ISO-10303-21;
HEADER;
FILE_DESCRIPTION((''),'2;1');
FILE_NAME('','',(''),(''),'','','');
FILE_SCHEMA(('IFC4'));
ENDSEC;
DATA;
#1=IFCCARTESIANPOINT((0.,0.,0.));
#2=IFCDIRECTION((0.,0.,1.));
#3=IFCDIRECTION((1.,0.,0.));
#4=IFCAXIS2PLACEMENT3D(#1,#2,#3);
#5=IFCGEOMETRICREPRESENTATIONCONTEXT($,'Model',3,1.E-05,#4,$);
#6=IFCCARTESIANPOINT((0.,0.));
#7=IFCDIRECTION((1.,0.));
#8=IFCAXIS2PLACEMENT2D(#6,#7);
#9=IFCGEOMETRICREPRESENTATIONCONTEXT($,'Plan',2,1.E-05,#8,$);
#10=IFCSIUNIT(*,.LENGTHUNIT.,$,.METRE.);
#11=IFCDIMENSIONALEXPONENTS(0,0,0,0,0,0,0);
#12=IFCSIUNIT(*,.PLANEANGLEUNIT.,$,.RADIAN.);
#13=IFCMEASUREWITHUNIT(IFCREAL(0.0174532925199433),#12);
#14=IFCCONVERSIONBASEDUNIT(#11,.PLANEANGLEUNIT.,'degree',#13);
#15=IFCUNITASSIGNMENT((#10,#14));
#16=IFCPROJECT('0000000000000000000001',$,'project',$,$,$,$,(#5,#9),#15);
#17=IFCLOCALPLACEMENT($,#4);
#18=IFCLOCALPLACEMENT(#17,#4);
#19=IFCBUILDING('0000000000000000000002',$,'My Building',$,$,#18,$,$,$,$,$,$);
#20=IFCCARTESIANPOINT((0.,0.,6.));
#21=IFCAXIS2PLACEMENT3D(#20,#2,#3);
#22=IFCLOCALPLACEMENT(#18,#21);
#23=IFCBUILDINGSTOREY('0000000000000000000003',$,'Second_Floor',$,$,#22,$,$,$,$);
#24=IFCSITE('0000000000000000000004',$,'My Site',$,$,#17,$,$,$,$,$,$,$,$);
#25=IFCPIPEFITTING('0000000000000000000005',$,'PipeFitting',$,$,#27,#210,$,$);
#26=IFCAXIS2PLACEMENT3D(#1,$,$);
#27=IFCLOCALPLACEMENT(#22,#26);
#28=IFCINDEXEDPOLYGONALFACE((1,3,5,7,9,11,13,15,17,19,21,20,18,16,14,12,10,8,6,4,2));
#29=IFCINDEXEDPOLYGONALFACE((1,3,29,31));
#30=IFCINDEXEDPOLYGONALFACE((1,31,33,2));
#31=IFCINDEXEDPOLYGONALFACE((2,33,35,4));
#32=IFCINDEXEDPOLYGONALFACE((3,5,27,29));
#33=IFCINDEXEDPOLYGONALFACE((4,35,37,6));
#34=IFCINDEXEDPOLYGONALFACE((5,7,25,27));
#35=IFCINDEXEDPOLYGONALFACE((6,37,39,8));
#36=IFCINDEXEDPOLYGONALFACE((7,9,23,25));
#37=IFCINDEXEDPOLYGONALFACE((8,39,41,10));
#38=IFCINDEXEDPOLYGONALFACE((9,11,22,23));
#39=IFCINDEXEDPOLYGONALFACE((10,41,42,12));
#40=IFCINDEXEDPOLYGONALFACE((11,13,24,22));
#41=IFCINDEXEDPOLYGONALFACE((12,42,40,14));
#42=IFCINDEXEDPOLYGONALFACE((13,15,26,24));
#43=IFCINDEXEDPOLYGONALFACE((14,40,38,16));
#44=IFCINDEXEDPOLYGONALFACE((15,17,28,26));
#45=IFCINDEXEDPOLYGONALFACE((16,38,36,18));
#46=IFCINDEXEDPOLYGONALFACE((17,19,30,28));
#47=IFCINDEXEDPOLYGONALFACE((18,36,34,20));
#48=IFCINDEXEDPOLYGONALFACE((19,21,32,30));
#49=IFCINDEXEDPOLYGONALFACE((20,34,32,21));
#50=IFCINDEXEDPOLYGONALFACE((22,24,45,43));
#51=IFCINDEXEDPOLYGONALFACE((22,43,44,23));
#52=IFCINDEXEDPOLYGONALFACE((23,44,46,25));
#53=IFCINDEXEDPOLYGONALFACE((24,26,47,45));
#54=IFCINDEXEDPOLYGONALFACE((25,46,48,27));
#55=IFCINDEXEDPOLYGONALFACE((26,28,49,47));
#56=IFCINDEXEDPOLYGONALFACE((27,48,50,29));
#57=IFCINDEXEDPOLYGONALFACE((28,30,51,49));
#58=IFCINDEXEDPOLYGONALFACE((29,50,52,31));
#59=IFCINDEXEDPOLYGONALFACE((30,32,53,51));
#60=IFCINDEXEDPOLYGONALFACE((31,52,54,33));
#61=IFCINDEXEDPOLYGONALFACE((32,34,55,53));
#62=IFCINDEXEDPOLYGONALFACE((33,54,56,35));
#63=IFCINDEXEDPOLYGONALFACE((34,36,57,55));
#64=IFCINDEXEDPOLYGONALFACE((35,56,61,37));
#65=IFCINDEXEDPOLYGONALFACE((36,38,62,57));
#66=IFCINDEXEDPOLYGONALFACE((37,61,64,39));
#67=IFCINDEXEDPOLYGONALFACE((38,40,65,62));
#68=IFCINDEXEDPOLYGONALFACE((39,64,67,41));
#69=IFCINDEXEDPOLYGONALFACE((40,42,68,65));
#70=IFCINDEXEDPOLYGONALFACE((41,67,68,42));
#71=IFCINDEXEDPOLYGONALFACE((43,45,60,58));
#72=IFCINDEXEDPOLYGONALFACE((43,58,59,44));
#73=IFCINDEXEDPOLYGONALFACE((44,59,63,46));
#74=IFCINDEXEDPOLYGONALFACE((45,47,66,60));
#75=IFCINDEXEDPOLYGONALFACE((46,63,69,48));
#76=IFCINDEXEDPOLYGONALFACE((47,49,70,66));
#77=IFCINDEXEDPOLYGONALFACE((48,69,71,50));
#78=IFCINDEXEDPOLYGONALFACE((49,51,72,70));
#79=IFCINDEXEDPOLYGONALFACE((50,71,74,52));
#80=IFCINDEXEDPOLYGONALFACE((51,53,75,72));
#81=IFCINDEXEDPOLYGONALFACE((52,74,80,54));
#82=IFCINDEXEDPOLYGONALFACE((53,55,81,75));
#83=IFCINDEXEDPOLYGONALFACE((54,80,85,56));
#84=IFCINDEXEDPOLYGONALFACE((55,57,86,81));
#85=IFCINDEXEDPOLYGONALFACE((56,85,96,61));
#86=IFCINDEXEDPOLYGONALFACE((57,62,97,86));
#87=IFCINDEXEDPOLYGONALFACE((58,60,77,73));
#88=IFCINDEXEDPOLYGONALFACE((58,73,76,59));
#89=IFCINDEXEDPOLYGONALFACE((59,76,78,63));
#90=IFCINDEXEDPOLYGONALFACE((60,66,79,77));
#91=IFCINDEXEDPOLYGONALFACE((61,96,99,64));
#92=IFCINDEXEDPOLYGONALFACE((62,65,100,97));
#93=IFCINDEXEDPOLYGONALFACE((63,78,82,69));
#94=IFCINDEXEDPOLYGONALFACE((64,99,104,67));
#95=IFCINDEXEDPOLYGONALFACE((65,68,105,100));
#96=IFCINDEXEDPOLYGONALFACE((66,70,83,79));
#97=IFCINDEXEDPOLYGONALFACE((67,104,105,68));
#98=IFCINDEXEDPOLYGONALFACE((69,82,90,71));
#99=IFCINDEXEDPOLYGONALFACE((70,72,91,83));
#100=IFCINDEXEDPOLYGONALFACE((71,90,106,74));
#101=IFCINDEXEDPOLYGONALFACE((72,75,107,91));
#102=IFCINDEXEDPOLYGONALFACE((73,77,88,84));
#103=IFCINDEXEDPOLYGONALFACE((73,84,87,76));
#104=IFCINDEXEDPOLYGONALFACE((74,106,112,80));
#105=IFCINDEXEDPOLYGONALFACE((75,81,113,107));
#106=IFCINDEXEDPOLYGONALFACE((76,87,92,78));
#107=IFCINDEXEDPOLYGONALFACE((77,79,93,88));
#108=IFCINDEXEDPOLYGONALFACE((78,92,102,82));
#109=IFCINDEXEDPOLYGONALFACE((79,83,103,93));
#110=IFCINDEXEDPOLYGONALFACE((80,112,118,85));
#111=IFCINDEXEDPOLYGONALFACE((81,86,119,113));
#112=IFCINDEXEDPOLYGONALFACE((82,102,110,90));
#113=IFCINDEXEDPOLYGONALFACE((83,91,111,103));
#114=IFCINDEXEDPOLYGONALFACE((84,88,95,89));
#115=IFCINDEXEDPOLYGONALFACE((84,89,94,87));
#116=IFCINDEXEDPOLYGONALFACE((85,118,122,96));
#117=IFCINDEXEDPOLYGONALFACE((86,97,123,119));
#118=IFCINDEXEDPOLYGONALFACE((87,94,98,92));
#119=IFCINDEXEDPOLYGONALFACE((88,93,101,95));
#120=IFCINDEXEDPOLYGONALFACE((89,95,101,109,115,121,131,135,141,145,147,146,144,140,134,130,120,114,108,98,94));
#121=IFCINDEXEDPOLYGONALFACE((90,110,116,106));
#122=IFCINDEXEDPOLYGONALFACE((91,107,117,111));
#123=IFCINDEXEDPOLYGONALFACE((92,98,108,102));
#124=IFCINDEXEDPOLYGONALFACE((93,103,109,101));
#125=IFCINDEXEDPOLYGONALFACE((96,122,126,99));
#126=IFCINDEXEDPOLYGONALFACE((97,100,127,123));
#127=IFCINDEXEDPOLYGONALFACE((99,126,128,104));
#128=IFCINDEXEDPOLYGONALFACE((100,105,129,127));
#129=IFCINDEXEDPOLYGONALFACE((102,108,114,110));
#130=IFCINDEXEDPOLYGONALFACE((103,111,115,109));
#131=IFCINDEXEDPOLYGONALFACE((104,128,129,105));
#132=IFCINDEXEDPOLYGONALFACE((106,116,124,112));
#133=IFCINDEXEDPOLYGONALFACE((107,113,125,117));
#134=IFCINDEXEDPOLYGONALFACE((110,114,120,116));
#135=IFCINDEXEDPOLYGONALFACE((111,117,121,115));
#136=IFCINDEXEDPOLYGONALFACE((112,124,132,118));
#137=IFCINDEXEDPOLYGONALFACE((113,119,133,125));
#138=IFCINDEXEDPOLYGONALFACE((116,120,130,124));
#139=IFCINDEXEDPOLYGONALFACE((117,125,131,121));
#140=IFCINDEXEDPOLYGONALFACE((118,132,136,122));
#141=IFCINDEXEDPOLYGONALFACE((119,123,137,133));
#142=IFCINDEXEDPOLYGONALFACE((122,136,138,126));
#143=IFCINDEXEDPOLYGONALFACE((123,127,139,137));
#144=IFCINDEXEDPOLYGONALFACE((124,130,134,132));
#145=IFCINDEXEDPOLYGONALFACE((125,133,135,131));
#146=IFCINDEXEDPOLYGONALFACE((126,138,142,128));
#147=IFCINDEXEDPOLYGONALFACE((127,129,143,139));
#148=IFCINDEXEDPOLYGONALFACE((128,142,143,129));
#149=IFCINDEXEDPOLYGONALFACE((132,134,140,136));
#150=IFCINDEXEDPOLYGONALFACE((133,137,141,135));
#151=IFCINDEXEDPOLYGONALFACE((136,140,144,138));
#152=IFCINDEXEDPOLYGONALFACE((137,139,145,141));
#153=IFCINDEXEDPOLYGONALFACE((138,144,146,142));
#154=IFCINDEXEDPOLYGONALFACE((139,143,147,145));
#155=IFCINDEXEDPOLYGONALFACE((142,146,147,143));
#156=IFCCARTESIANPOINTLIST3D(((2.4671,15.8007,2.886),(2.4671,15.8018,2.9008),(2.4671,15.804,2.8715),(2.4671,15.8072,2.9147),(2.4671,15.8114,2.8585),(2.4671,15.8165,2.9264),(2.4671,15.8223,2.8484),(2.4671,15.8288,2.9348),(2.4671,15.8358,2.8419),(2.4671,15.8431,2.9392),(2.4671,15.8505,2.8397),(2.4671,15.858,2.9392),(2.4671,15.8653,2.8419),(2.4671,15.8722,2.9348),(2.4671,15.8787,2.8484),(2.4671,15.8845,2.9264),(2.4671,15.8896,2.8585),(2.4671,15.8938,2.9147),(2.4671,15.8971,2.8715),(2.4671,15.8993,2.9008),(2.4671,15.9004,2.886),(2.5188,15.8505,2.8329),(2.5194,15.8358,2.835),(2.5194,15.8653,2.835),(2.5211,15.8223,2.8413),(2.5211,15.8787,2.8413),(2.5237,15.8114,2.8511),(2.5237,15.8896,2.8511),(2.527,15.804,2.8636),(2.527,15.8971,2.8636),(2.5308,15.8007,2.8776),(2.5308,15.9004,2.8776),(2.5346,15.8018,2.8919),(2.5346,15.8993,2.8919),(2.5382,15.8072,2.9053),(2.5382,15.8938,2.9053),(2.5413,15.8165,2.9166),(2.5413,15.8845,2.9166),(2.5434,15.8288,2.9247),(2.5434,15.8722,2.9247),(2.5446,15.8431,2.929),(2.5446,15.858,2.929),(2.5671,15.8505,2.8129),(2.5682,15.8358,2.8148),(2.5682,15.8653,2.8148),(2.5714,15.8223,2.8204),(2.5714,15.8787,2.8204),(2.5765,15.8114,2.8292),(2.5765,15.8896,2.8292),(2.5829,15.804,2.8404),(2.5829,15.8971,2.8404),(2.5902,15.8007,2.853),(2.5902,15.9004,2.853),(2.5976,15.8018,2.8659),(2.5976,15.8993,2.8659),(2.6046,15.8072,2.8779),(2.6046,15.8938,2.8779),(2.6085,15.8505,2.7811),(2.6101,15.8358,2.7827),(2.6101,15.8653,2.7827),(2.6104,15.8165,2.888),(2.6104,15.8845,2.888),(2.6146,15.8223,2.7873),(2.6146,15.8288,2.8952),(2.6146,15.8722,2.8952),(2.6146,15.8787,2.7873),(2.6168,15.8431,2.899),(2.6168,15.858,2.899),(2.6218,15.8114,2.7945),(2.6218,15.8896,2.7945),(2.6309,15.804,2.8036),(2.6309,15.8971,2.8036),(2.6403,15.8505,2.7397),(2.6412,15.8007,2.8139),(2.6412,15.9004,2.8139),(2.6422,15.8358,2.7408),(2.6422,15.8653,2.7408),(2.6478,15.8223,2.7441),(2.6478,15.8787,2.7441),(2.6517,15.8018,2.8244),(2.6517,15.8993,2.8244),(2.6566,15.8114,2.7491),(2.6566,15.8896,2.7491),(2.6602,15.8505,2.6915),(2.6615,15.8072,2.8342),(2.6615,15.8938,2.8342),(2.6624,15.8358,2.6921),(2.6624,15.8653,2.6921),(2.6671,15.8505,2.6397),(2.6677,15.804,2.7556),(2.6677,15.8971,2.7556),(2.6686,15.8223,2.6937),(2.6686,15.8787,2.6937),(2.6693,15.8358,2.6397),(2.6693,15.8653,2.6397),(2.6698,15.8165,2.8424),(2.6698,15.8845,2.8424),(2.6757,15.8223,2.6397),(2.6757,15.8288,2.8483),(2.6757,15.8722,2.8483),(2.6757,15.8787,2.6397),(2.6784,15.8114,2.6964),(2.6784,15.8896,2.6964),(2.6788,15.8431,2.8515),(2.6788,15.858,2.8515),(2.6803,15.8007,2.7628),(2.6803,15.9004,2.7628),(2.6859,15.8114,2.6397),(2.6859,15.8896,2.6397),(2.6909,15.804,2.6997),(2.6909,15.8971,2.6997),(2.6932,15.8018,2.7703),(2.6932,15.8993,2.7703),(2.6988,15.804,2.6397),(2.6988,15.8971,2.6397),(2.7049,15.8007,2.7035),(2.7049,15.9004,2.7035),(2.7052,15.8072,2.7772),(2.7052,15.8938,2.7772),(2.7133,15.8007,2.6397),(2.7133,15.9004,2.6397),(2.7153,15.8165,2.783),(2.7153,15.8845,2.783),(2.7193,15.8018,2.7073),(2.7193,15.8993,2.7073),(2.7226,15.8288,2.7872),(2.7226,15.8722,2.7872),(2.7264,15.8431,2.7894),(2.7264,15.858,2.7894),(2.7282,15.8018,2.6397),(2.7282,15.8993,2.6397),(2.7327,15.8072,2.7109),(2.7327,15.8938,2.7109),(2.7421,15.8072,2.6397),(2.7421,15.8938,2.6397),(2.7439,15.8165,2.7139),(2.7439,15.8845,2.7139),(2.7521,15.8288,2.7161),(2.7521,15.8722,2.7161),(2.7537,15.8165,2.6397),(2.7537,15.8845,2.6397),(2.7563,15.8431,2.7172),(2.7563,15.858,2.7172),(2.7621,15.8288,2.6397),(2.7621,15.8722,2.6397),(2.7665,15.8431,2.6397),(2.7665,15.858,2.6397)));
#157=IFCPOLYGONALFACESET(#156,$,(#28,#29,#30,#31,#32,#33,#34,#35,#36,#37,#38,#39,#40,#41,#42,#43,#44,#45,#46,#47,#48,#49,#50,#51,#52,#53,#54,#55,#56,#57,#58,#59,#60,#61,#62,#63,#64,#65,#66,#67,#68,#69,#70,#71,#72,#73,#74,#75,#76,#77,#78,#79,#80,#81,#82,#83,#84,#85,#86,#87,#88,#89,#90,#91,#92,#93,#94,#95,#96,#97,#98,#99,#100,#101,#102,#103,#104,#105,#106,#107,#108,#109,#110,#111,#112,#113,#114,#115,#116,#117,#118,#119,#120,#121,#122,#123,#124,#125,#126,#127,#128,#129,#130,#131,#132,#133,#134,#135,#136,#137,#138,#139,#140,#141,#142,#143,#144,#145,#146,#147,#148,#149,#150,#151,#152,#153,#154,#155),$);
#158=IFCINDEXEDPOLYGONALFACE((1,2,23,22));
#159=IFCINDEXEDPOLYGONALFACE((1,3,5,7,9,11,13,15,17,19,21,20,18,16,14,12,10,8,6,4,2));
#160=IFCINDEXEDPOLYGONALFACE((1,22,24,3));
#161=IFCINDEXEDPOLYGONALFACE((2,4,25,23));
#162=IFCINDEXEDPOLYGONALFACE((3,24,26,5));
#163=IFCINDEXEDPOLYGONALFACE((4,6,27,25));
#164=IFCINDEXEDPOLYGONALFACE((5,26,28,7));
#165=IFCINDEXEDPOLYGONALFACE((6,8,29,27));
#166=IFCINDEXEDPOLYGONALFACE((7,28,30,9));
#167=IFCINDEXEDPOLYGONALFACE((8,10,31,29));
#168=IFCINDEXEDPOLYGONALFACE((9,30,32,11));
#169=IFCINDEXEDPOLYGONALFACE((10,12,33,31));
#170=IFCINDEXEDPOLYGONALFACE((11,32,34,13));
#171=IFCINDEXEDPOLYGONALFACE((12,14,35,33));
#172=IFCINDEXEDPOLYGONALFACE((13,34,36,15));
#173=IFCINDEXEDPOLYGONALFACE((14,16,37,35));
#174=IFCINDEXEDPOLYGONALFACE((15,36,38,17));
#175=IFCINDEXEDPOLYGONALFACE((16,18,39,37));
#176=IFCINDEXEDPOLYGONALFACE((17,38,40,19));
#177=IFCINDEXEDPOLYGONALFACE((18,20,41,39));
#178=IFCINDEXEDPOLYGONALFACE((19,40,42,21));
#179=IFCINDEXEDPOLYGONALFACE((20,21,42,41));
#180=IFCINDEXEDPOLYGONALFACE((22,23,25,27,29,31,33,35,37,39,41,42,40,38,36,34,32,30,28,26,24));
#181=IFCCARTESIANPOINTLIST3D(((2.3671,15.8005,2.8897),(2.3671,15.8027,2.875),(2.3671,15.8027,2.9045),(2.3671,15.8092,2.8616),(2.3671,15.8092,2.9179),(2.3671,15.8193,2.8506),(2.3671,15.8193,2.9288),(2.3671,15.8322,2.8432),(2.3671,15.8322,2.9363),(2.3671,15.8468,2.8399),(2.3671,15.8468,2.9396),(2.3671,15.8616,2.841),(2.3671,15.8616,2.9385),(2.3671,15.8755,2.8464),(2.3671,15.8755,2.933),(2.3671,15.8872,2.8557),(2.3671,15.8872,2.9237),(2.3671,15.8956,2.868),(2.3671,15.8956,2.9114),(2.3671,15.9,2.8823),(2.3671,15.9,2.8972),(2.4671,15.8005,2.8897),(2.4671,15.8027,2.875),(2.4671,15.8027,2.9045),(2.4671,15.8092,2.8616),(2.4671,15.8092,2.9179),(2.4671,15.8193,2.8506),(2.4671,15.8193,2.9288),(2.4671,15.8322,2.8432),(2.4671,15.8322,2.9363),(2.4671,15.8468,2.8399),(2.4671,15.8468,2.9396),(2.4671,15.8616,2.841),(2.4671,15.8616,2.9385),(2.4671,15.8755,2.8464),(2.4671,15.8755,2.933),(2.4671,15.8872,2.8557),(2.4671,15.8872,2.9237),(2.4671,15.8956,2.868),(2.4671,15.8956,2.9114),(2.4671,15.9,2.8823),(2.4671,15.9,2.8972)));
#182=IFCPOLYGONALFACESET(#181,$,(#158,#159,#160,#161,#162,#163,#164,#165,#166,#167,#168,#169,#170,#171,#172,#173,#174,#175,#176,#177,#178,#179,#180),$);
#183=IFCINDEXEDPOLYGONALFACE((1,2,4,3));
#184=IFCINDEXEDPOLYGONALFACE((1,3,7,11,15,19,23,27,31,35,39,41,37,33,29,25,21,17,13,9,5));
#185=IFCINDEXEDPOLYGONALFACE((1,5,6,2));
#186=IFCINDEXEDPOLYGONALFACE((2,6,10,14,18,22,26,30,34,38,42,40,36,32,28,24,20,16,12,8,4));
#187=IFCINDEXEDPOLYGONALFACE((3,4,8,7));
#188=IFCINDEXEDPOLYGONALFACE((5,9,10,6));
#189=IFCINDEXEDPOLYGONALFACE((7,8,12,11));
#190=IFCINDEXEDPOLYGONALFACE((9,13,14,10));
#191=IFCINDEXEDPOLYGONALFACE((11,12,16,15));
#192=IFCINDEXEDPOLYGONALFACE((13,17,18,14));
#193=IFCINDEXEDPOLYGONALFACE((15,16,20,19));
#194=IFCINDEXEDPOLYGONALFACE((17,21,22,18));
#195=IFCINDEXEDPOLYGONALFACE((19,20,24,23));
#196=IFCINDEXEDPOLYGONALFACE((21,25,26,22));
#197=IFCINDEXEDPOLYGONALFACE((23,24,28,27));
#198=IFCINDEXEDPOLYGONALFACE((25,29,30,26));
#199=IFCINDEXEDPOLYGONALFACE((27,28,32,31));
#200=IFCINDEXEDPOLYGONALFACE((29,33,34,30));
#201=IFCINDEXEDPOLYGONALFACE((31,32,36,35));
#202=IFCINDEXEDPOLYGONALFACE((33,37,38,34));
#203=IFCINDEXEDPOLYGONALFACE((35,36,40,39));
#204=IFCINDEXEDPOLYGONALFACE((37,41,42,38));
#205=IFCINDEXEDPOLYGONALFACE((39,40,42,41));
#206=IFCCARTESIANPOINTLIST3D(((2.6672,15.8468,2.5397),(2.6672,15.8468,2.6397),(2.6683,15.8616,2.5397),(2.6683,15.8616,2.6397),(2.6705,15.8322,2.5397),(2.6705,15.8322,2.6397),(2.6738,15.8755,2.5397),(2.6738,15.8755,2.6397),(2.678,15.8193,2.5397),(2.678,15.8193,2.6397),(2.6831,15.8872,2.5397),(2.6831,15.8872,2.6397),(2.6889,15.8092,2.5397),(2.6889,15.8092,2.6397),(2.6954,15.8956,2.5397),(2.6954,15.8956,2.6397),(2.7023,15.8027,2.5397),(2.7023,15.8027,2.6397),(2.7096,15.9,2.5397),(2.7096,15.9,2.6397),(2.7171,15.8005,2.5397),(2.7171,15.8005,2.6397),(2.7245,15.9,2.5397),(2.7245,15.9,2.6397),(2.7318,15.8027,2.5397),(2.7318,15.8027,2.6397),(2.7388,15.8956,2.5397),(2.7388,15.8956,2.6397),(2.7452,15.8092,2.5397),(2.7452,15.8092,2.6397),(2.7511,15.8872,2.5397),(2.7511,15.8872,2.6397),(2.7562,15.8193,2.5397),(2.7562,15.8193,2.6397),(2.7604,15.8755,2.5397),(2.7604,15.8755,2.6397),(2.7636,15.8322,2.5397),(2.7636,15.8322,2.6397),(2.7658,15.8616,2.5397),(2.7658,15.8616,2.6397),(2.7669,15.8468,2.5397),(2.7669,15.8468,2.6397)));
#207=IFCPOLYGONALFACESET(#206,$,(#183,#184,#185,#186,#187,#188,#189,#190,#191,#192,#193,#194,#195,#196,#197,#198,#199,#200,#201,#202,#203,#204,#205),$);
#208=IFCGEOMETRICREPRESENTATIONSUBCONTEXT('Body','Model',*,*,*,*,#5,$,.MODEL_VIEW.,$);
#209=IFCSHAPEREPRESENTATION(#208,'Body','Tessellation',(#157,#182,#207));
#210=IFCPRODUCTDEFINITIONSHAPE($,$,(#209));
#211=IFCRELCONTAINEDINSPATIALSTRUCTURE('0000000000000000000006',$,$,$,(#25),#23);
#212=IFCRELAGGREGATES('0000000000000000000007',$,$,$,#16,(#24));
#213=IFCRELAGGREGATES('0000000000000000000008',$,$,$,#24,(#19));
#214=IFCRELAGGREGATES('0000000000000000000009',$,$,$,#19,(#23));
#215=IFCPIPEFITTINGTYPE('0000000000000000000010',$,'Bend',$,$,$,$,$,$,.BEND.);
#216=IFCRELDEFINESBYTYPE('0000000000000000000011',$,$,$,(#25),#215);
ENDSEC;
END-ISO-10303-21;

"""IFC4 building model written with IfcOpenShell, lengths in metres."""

from ifc_helpers import new_model, entity, si_unit, converted_unit, frame, origin_with_axes, origin_2d_with_axis, place, context, subcontext, project, spatial, circle, extrude, source, transform, mapped, type_object, type_shapes, element, save


model = new_model("IFC4")

# Units and contexts
model_context = context("Model", 3, precision=1e-05, world=origin_with_axes())
plan_context = context("Plan", 2, precision=1e-05, world=origin_2d_with_axis())
body_context_1 = subcontext(model_context, "Body", "Model", "MODEL_VIEW")
ifc_project = project(units=[si_unit("LENGTHUNIT", "METRE"), converted_unit("PLANEANGLEUNIT", "degree", entity("IfcReal", 0.0174532925199433), si_unit("PLANEANGLEUNIT", "RADIAN"), dimensions=[0, 0, 0, 0, 0, 0, 0])], contexts=[model_context, plan_context])

# Site, building, storey
site_placement = place(None, origin_with_axes())
site = spatial("IfcSite", under=ifc_project, at=site_placement, Name="My Site")
building_placement = place(site_placement, origin_with_axes())
building = spatial("IfcBuilding", under=site, at=building_placement, Name="My Building")
storey_placement = place(building_placement, frame((0.0, 0.0, 6.0), z_axis=(0.0, 0.0, 1.0), x_axis=(1.0, 0.0, 0.0)))
storey = spatial("IfcBuildingStorey", under=building, at=storey_placement, Name="Second_Floor")

# Pipe fitting
pipe_fitting_type = type_object("IfcPipeFittingType", Name="Bend", PredefinedType="BEND")
shared_shape_1 = source(origin_with_axes(), body_context_1, "Body", "SolidModel", [
    entity("IfcSweptDiskSolid", entity("IfcIndexedPolyCurve", entity("IfcCartesianPointList3D", [[0.0, 0.0, -0.1], [0.0, -0.0732, -0.2768], [0.0, -0.25, -0.35]]), [entity("IfcArcIndex", [1, 2, 3])]), 0.05),
    extrude(circle(Radius=0.05), origin_with_axes(), (0.0, 0.0, -1.0), 0.1),
    extrude(circle(Radius=0.05), frame((0.0, -0.25, -0.35), z_axis=(0.0, -1.0, 0.0), x_axis=(1.0, 0.0, 0.0)), (0.0, 0.0, 1.0), 0.1),
])
type_shapes(pipe_fitting_type, [shared_shape_1])
for number, where, z_axis, x_axis, name in (
    (1, (2.3671, 15.8505, 2.8897), (-1.0, 0.0, 0.0), (0.0, -1.0, 0.0), "PipeFitting"),
):
    element("IfcPipeFitting", number, at=place(storey_placement, frame(where, z_axis=z_axis, x_axis=x_axis)), inside=storey, type_object=pipe_fitting_type, Name=name, context=body_context_1, shape_type="MappedRepresentation", body=[
        mapped(shared_shape_1, transform((0.0, 0.0, 0.0), x_axis=(1.0, 0.0, 0.0), y_axis=(0.0, 1.0, 0.0), z_axis=(0.0, 0.0, 1.0), scale=1.0)),
    ])

save(model, "model.ifc")
